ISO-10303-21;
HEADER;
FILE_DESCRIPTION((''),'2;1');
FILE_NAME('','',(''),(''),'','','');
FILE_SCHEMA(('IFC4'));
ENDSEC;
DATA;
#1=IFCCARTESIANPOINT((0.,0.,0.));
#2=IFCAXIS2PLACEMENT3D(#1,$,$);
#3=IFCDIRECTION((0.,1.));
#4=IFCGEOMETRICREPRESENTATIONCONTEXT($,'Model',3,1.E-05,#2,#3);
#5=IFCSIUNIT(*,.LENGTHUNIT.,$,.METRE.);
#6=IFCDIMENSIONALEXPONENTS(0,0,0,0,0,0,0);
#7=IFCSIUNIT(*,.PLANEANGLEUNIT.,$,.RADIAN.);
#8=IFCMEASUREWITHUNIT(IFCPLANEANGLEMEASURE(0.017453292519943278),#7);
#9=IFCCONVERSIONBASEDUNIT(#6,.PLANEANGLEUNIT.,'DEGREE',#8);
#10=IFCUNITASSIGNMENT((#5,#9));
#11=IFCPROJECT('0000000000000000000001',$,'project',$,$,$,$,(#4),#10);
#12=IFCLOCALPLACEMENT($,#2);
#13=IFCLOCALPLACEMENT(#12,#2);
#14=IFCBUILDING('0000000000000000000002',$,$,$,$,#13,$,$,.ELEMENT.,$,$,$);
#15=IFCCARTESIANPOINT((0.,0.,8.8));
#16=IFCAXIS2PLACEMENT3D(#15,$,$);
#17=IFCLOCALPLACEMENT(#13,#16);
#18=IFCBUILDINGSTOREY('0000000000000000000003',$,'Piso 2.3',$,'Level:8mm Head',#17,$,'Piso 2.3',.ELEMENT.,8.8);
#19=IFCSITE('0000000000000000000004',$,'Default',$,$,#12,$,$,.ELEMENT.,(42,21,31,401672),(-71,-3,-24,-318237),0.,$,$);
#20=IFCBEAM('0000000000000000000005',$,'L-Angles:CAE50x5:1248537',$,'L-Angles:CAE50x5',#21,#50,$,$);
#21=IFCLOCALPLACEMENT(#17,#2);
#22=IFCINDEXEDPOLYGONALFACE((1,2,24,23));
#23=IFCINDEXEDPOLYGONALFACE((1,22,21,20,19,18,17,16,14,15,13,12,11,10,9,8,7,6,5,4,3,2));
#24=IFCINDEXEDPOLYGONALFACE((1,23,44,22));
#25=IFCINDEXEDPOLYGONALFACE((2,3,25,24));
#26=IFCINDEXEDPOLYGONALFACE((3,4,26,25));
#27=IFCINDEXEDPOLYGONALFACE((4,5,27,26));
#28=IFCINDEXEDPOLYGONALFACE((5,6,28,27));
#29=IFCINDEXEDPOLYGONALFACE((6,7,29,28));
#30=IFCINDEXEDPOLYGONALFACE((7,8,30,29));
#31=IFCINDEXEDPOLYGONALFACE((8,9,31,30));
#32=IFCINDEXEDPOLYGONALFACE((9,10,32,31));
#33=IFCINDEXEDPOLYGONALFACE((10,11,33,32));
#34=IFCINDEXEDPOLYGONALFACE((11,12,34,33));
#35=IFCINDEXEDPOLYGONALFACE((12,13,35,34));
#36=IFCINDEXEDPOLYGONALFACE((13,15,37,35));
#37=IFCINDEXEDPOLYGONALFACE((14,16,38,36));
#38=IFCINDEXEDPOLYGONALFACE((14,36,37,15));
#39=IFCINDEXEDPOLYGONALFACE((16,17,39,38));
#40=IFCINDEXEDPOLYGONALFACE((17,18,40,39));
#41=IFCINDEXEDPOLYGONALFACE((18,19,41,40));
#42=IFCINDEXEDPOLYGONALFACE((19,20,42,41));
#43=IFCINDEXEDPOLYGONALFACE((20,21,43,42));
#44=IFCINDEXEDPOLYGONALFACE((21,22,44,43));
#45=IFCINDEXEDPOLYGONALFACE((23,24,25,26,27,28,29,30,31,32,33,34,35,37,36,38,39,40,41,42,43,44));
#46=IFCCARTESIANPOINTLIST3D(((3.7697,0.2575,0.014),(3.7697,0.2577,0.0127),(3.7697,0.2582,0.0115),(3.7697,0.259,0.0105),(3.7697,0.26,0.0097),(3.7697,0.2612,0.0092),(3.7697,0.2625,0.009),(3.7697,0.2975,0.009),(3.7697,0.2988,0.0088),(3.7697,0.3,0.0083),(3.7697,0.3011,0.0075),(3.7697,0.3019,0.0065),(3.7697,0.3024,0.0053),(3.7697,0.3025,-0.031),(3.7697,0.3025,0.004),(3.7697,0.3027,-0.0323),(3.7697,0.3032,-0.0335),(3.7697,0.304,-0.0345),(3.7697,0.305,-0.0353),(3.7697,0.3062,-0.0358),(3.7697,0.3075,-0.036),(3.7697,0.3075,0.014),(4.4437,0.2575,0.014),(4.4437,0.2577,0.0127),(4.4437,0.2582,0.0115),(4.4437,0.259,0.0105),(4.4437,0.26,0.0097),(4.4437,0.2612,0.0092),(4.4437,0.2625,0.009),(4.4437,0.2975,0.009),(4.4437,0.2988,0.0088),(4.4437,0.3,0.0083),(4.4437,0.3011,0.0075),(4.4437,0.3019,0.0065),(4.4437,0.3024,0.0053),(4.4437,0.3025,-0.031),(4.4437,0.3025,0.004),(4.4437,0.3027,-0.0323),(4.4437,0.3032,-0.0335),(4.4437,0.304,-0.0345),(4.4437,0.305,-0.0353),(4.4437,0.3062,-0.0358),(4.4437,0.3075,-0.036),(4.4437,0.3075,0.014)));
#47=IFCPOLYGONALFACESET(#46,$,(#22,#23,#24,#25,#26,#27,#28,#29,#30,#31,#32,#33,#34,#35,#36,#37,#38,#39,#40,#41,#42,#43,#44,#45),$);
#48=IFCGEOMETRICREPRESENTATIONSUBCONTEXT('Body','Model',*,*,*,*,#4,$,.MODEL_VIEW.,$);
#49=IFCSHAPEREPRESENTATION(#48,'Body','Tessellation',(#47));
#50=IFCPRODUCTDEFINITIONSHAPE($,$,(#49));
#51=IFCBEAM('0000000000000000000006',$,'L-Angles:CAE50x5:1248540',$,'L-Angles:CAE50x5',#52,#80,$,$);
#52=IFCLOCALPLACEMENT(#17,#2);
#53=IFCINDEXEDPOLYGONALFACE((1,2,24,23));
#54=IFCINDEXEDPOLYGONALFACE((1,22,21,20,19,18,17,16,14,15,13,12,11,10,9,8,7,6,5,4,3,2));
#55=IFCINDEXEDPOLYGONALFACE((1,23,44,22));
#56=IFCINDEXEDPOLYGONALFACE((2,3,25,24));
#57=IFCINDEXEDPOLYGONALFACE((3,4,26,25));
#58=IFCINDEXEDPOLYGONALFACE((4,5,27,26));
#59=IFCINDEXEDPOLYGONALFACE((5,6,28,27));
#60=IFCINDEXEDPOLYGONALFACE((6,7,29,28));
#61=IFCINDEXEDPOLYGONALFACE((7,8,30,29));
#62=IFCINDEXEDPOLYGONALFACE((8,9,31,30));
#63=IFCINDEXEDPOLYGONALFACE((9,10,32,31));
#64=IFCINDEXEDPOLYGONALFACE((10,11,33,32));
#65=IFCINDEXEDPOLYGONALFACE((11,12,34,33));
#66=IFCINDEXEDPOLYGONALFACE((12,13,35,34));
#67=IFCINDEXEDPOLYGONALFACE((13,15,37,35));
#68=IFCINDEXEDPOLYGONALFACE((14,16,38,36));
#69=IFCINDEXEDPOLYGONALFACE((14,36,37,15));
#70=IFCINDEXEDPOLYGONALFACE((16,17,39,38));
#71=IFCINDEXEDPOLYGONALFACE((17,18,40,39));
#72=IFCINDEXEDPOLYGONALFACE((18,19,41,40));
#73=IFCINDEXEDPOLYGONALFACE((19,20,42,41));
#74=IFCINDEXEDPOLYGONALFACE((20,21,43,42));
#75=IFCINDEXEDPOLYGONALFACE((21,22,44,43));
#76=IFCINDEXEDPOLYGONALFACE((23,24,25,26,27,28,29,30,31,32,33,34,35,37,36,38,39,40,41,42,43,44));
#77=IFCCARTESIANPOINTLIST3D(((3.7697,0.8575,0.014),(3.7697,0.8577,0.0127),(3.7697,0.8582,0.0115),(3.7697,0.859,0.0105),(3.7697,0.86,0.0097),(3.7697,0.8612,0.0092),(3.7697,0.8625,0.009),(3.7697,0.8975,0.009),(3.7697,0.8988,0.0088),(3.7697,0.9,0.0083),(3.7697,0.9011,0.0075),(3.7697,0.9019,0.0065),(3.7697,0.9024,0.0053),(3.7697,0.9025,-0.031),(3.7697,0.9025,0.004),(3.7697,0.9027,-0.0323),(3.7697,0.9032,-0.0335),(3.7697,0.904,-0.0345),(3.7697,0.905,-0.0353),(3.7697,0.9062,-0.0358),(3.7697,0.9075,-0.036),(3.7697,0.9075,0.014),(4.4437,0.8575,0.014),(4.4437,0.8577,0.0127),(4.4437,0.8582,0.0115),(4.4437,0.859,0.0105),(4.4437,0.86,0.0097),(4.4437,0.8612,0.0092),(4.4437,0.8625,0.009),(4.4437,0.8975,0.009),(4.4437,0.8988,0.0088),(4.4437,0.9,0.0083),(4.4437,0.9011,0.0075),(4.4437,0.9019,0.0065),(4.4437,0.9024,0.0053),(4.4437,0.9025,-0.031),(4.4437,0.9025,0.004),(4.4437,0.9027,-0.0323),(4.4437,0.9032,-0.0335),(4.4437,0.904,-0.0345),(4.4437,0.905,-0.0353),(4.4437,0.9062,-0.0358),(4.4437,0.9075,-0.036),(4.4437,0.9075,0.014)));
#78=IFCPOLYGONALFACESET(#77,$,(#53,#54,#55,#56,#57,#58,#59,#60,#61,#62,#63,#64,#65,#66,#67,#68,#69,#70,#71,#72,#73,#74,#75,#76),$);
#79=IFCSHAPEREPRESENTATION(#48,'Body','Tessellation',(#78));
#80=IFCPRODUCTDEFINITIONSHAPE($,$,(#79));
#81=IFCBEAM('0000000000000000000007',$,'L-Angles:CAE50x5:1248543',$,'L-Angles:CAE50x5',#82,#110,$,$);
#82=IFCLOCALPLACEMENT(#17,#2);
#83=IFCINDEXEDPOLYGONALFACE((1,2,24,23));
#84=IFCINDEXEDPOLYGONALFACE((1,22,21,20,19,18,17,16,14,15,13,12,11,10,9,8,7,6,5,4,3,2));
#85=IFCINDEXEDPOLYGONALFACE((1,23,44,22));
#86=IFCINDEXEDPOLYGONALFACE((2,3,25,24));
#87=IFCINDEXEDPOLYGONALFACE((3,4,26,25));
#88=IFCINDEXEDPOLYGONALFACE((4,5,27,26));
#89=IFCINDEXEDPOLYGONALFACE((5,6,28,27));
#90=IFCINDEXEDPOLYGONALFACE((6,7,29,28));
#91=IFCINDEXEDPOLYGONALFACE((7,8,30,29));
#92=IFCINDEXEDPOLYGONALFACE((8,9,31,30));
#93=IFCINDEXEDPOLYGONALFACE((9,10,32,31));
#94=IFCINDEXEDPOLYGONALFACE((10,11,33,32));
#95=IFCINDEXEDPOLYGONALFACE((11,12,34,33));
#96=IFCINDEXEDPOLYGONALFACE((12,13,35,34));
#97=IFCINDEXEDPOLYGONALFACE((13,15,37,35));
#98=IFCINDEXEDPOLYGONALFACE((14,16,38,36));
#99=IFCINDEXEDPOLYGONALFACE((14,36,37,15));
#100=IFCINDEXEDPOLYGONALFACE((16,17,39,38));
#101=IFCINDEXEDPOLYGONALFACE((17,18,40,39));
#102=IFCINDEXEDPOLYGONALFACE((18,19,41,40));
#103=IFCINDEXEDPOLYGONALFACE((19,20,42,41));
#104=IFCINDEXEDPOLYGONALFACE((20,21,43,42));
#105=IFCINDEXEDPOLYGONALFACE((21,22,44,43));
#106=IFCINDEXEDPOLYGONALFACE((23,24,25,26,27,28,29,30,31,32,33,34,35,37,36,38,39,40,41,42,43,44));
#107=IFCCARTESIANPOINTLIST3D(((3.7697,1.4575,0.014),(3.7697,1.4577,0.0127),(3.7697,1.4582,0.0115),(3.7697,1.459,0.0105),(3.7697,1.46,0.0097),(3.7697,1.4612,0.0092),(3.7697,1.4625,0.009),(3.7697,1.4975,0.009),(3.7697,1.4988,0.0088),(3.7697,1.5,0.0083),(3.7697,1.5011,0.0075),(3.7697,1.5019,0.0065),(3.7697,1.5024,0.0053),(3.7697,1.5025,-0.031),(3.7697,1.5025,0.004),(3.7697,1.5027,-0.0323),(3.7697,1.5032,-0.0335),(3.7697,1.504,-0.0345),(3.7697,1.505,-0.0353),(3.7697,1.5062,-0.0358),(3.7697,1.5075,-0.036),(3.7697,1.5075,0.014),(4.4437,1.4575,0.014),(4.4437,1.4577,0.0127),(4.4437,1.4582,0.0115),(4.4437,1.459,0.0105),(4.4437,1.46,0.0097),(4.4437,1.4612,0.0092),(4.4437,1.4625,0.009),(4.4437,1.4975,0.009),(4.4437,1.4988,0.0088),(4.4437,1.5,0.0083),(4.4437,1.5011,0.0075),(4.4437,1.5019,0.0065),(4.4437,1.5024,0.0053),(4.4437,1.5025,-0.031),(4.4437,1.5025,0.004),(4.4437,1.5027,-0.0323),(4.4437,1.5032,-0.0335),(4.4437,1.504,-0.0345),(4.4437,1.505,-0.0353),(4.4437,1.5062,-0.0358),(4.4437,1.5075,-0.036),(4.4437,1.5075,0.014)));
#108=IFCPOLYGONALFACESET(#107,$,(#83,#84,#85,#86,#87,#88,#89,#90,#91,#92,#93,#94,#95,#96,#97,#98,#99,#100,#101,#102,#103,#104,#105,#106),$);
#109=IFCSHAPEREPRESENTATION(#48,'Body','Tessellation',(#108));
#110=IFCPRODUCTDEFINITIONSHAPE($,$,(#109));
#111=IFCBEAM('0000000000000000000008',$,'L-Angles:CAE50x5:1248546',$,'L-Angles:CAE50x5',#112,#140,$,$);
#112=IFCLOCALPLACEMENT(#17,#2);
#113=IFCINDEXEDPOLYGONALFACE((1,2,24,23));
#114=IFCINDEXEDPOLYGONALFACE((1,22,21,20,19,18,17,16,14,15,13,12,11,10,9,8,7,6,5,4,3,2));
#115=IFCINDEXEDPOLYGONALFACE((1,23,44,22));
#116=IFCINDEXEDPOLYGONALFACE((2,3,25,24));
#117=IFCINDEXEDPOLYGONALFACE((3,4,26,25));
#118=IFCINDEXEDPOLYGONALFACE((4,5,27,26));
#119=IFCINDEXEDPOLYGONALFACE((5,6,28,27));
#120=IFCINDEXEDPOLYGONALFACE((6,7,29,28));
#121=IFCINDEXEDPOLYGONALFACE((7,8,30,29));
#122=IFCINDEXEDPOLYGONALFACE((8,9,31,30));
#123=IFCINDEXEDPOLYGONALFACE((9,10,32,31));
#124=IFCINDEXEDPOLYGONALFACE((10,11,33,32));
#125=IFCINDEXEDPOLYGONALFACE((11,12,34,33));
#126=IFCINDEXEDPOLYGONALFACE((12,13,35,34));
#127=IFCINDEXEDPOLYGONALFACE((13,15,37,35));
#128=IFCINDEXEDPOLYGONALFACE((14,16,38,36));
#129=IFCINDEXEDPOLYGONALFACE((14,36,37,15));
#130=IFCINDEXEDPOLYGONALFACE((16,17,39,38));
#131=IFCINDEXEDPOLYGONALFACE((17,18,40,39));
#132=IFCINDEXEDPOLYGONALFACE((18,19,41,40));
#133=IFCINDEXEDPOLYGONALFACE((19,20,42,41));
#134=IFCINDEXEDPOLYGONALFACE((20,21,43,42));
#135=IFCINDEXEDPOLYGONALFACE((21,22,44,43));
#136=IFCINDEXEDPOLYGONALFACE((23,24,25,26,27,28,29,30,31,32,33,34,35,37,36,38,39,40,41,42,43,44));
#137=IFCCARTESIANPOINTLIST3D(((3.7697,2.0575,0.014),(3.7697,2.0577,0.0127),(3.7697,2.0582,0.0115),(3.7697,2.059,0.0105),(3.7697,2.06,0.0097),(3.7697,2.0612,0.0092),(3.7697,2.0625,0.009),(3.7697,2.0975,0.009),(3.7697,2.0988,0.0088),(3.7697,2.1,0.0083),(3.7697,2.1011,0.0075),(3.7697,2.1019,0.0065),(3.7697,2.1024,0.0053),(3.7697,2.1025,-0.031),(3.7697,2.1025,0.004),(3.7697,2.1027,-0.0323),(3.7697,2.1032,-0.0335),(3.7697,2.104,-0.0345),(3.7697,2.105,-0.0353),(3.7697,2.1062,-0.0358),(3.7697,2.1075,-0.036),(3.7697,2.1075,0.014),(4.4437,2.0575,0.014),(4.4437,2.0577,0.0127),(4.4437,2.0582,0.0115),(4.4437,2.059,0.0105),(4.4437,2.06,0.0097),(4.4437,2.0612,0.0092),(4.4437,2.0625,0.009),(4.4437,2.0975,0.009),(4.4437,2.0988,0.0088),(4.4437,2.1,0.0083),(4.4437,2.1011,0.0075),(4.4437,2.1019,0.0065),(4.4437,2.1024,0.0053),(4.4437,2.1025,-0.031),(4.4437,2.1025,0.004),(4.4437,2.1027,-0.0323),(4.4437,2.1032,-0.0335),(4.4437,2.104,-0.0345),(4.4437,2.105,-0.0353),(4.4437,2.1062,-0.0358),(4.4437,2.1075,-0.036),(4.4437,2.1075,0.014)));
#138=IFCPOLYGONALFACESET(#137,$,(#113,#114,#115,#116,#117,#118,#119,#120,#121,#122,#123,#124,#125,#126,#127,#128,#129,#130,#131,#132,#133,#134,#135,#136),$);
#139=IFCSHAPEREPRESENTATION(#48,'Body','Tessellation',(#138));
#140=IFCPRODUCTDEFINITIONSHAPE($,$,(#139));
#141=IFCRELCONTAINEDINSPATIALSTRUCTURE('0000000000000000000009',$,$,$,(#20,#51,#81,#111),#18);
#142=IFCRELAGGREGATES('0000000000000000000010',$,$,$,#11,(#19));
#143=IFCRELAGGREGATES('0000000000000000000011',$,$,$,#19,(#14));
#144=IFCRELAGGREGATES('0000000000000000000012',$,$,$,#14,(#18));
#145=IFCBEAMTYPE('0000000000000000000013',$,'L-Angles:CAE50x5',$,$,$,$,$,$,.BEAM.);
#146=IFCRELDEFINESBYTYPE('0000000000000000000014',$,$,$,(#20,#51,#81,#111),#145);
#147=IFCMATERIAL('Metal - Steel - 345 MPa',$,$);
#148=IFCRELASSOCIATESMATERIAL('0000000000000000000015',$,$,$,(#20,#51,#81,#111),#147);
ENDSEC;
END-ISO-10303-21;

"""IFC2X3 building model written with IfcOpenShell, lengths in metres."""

from ifc_helpers import new_model, entity, si_unit, converted_unit, direction, frame, frame_2d, origin, place, context, subcontext, project, spatial, polyline, circle_curve, parameter, trimmed, segment, composite_curve, outline, extrude, material, type_object, element, save


model = new_model("IFC2X3")

# Units and contexts
model_context = context("Model", 3, precision=1e-05, world=origin(), true_north=direction((0.0, 1.0)))
body_context = subcontext(model_context, "Body", "Model", "MODEL_VIEW")
ifc_project = project(units=[si_unit("LENGTHUNIT", "METRE"), converted_unit("PLANEANGLEUNIT", "DEGREE", entity("IfcPlaneAngleMeasure", 0.017453292519943278), si_unit("PLANEANGLEUNIT", "RADIAN"), dimensions=[0, 0, 0, 0, 0, 0, 0])], contexts=[model_context])

# Site, building, storey
site_placement = place(None, origin())
site = spatial("IfcSite", under=ifc_project, at=site_placement, Name="Default", CompositionType="ELEMENT", RefLatitude=(42, 21, 31, 401672), RefLongitude=(-71, -3, -24, -318237), RefElevation=0.0)
building_placement = place(site_placement, origin())
building = spatial("IfcBuilding", under=site, at=building_placement, CompositionType="ELEMENT")
storey_placement = place(building_placement, frame((0.0, 0.0, 8.8)))
storey = spatial("IfcBuildingStorey", under=building, at=storey_placement, Name="Piso 2.3", ObjectType="Level:8mm Head", LongName="Piso 2.3", CompositionType="ELEMENT", Elevation=8.8)

# Shared definitions
ifc_material_1 = material(Name="Metal - Steel - 345 MPa")

# Beams
beam_type_1 = type_object("IfcBeamType", Name="L-Angles:CAE50x5", PredefinedType="BEAM")
beam_1_placement = place(storey_placement, frame((3.7067, 0.2935, 0.0)))
element("IfcBeam", 1, at=beam_1_placement, inside=storey, type_object=beam_type_1, material=ifc_material_1, Name="L-Angles:CAE50x5:1248537", ObjectType="L-Angles:CAE50x5", context=body_context, shape_type="SweptSolid", body=[
    extrude(outline(composite_curve([segment(polyline([(-0.0336, -0.0164), (0.0164, -0.0164)]), True, "CONTINUOUS"), segment(polyline([(0.0164, -0.0164), (0.0164, 0.0336)]), True, "CONTINUOUS"), segment(trimmed(circle_curve(frame_2d((0.0164, 0.0286), x_axis=(0.0, 1.0)), 0.005), [parameter(0.0)], [parameter(90.0)], True, "PARAMETER"), True, "CONTINUOUS"), segment(polyline([(0.0114, 0.0286), (0.0114, -0.0064)]), True, "CONTINUOUS"), segment(trimmed(circle_curve(frame_2d((0.0064, -0.0064), x_axis=(1.0, 0.0)), 0.005), [parameter(270.0)], [parameter(0.0)], True, "PARAMETER"), False, "CONTINUOUS"), segment(polyline([(0.0064, -0.0114), (-0.0286, -0.0114)]), True, "CONTINUOUS"), segment(trimmed(circle_curve(frame_2d((-0.0286, -0.0164), x_axis=(0.0, 1.0)), 0.005), [parameter(0.0)], [parameter(90.0)], True, "PARAMETER"), True, "CONTINUOUS")], self_intersect=False)), frame((0.063, -0.0024, -0.0024), z_axis=(1.0, 0.0, 0.0), x_axis=(0.0, 0.0, 1.0)), (0.0, 0.0, 1.0), 0.674),
])
beam_2_placement = place(storey_placement, frame((3.7067, 0.8935, 0.0)))
element("IfcBeam", 2, at=beam_2_placement, inside=storey, type_object=beam_type_1, material=ifc_material_1, Name="L-Angles:CAE50x5:1248540", ObjectType="L-Angles:CAE50x5", context=body_context, shape_type="SweptSolid", body=[
    extrude(outline(composite_curve([segment(polyline([(-0.0336, -0.0164), (0.0164, -0.0164)]), True, "CONTINUOUS"), segment(polyline([(0.0164, -0.0164), (0.0164, 0.0336)]), True, "CONTINUOUS"), segment(trimmed(circle_curve(frame_2d((0.0164, 0.0286), x_axis=(0.0, 1.0)), 0.005), [parameter(0.0)], [parameter(90.0)], True, "PARAMETER"), True, "CONTINUOUS"), segment(polyline([(0.0114, 0.0286), (0.0114, -0.0064)]), True, "CONTINUOUS"), segment(trimmed(circle_curve(frame_2d((0.0064, -0.0064), x_axis=(1.0, 0.0)), 0.005), [parameter(270.0)], [parameter(0.0)], True, "PARAMETER"), False, "CONTINUOUS"), segment(polyline([(0.0064, -0.0114), (-0.0286, -0.0114)]), True, "CONTINUOUS"), segment(trimmed(circle_curve(frame_2d((-0.0286, -0.0164), x_axis=(0.0, 1.0)), 0.005), [parameter(0.0)], [parameter(90.0)], True, "PARAMETER"), True, "CONTINUOUS")], self_intersect=False)), frame((0.063, -0.0024, -0.0024), z_axis=(1.0, 0.0, 0.0), x_axis=(0.0, 0.0, 1.0)), (0.0, 0.0, 1.0), 0.674),
])
beam_3_placement = place(storey_placement, frame((3.7067, 1.4935, 0.0)))
element("IfcBeam", 3, at=beam_3_placement, inside=storey, type_object=beam_type_1, material=ifc_material_1, Name="L-Angles:CAE50x5:1248543", ObjectType="L-Angles:CAE50x5", context=body_context, shape_type="SweptSolid", body=[
    extrude(outline(composite_curve([segment(polyline([(-0.0336, -0.0164), (0.0164, -0.0164)]), True, "CONTINUOUS"), segment(polyline([(0.0164, -0.0164), (0.0164, 0.0336)]), True, "CONTINUOUS"), segment(trimmed(circle_curve(frame_2d((0.0164, 0.0286), x_axis=(0.0, 1.0)), 0.005), [parameter(0.0)], [parameter(90.0)], True, "PARAMETER"), True, "CONTINUOUS"), segment(polyline([(0.0114, 0.0286), (0.0114, -0.0064)]), True, "CONTINUOUS"), segment(trimmed(circle_curve(frame_2d((0.0064, -0.0064), x_axis=(1.0, 0.0)), 0.005), [parameter(270.0)], [parameter(0.0)], True, "PARAMETER"), False, "CONTINUOUS"), segment(polyline([(0.0064, -0.0114), (-0.0286, -0.0114)]), True, "CONTINUOUS"), segment(trimmed(circle_curve(frame_2d((-0.0286, -0.0164), x_axis=(0.0, 1.0)), 0.005), [parameter(0.0)], [parameter(90.0)], True, "PARAMETER"), True, "CONTINUOUS")], self_intersect=False)), frame((0.063, -0.0024, -0.0024), z_axis=(1.0, 0.0, 0.0), x_axis=(0.0, 0.0, 1.0)), (0.0, 0.0, 1.0), 0.674),
])
beam_4_placement = place(storey_placement, frame((3.7067, 2.0935, 0.0)))
element("IfcBeam", 4, at=beam_4_placement, inside=storey, type_object=beam_type_1, material=ifc_material_1, Name="L-Angles:CAE50x5:1248546", ObjectType="L-Angles:CAE50x5", context=body_context, shape_type="SweptSolid", body=[
    extrude(outline(composite_curve([segment(polyline([(-0.0336, -0.0164), (0.0164, -0.0164)]), True, "CONTINUOUS"), segment(polyline([(0.0164, -0.0164), (0.0164, 0.0336)]), True, "CONTINUOUS"), segment(trimmed(circle_curve(frame_2d((0.0164, 0.0286), x_axis=(0.0, 1.0)), 0.005), [parameter(0.0)], [parameter(90.0)], True, "PARAMETER"), True, "CONTINUOUS"), segment(polyline([(0.0114, 0.0286), (0.0114, -0.0064)]), True, "CONTINUOUS"), segment(trimmed(circle_curve(frame_2d((0.0064, -0.0064), x_axis=(1.0, 0.0)), 0.005), [parameter(270.0)], [parameter(0.0)], True, "PARAMETER"), False, "CONTINUOUS"), segment(polyline([(0.0064, -0.0114), (-0.0286, -0.0114)]), True, "CONTINUOUS"), segment(trimmed(circle_curve(frame_2d((-0.0286, -0.0164), x_axis=(0.0, 1.0)), 0.005), [parameter(0.0)], [parameter(90.0)], True, "PARAMETER"), True, "CONTINUOUS")], self_intersect=False)), frame((0.063, -0.0024, -0.0024), z_axis=(1.0, 0.0, 0.0), x_axis=(0.0, 0.0, 1.0)), (0.0, 0.0, 1.0), 0.674),
])

save(model, "model.ifc")
